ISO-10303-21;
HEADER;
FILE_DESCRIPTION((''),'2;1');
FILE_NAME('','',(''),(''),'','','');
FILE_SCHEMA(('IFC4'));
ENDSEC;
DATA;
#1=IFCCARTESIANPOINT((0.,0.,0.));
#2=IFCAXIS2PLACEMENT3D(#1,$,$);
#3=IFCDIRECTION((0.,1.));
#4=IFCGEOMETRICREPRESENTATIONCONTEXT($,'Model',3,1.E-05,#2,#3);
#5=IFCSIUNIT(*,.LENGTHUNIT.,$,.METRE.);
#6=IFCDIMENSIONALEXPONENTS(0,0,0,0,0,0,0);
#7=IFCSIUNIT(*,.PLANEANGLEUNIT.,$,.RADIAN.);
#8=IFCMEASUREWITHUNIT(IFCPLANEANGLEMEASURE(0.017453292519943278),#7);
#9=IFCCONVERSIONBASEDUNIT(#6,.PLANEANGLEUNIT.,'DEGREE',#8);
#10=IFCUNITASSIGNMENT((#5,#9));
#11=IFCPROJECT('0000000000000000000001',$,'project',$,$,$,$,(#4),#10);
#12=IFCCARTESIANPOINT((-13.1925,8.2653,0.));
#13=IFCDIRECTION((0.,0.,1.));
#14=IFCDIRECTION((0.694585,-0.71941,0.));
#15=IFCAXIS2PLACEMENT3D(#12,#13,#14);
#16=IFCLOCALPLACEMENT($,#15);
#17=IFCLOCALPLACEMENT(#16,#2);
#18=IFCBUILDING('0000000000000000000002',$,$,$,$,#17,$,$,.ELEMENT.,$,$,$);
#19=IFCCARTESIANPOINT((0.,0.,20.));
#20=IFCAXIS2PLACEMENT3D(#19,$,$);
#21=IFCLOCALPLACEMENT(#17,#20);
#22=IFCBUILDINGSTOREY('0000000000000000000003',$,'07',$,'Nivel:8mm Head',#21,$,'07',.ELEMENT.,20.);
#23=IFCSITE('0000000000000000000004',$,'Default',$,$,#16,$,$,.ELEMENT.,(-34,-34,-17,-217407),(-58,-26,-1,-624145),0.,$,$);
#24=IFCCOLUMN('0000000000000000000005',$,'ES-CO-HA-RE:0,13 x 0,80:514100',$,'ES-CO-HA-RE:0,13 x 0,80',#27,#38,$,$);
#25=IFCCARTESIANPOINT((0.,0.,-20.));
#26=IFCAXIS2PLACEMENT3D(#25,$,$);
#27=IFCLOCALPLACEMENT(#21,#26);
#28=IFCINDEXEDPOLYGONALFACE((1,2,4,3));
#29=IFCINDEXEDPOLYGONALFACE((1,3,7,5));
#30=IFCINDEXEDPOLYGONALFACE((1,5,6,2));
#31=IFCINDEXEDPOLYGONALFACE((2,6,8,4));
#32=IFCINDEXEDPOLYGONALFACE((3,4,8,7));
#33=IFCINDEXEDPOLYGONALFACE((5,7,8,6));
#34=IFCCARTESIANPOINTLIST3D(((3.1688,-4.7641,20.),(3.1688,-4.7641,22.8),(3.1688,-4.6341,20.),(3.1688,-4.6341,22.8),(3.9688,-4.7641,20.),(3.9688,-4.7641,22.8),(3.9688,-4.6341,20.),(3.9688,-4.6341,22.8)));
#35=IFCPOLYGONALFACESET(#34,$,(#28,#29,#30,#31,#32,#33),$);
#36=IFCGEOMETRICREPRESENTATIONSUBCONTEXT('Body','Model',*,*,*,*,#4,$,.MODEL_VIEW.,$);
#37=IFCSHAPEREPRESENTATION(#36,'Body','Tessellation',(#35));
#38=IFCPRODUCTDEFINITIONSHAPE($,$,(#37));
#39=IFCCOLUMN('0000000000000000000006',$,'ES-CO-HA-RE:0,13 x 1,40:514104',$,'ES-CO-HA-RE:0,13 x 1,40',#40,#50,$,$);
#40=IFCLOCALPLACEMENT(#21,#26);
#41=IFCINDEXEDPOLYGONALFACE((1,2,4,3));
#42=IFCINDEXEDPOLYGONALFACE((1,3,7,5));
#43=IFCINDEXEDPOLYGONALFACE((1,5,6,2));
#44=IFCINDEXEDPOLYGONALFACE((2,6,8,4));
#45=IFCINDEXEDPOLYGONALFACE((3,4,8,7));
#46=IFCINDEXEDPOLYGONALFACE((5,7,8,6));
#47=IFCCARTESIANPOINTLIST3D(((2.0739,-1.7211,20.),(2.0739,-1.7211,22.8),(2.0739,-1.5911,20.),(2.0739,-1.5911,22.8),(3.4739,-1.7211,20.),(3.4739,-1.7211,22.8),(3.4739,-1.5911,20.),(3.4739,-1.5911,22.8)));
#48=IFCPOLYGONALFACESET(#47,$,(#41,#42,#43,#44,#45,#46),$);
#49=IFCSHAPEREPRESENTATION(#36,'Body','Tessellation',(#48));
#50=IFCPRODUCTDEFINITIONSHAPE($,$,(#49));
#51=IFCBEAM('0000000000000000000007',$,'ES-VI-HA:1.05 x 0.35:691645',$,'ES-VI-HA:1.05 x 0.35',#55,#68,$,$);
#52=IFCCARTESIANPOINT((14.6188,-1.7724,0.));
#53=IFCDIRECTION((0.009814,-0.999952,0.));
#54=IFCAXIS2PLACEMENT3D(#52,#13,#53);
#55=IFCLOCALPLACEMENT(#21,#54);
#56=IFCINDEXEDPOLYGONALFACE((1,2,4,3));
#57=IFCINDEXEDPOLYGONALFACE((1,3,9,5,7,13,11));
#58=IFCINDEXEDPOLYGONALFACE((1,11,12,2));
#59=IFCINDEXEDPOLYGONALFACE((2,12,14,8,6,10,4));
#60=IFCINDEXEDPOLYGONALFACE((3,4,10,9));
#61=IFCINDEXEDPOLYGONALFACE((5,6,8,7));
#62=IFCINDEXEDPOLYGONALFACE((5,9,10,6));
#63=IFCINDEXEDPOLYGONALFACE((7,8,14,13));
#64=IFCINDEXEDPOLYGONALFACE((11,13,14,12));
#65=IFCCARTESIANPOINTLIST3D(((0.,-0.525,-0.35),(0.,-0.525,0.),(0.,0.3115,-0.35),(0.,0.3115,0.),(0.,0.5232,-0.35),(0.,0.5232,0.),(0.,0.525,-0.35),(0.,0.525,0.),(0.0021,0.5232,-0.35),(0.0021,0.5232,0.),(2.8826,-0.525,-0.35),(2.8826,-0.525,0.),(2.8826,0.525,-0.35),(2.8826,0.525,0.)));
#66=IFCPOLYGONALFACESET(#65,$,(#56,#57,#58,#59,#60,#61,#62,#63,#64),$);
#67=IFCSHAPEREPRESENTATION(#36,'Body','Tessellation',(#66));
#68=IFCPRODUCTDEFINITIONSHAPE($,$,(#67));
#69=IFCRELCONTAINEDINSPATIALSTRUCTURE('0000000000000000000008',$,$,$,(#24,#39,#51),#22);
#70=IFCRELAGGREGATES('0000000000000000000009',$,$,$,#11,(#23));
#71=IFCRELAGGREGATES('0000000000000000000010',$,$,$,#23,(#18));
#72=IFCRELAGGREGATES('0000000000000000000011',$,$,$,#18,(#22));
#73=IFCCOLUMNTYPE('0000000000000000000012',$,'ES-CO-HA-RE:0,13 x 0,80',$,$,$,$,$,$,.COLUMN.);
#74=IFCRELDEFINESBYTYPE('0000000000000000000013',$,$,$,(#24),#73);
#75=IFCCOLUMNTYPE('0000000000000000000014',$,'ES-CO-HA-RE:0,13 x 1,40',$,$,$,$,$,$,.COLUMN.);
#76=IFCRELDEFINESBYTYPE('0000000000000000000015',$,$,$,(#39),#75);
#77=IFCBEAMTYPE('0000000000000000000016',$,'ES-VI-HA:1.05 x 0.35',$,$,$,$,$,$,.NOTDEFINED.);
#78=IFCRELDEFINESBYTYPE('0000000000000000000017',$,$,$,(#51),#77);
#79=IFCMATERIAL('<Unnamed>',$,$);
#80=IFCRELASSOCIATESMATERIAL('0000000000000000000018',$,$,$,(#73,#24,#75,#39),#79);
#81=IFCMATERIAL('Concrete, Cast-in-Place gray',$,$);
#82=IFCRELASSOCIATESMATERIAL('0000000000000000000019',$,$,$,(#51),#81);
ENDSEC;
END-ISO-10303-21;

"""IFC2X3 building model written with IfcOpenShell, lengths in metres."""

from ifc_helpers import new_model, entity, si_unit, converted_unit, direction, frame, frame_2d, origin, place, context, subcontext, project, spatial, polyline, rectangle, extrude, clip, bounded_halfspace, source, transform, mapped, material, type_object, type_shapes, element, save


model = new_model("IFC2X3")

# Units and contexts
model_context = context("Model", 3, precision=1e-05, world=origin(), true_north=direction((0.0, 1.0)))
body_context = subcontext(model_context, "Body", "Model", "MODEL_VIEW")
ifc_project = project(units=[si_unit("LENGTHUNIT", "METRE"), converted_unit("PLANEANGLEUNIT", "DEGREE", entity("IfcPlaneAngleMeasure", 0.017453292519943278), si_unit("PLANEANGLEUNIT", "RADIAN"), dimensions=[0, 0, 0, 0, 0, 0, 0])], contexts=[model_context])

# Site, building, storey
site_placement = place(None, frame((-13.1925, 8.2653, 0.0), z_axis=(0.0, 0.0, 1.0), x_axis=(0.694585, -0.71941, 0.0)))
site = spatial("IfcSite", under=ifc_project, at=site_placement, Name="Default", CompositionType="ELEMENT", RefLatitude=(-34, -34, -17, -217407), RefLongitude=(-58, -26, -1, -624145), RefElevation=0.0)
building_placement = place(site_placement, origin())
building = spatial("IfcBuilding", under=site, at=building_placement, CompositionType="ELEMENT")
storey_placement = place(building_placement, frame((0.0, 0.0, 20.0)))
storey = spatial("IfcBuildingStorey", under=building, at=storey_placement, Name="07", ObjectType="Nivel:8mm Head", LongName="07", CompositionType="ELEMENT", Elevation=20.0)

# Columns
ifc_material_1 = material(Name="<Unnamed>")
column_type_1 = type_object("IfcColumnType", Name="ES-CO-HA-RE:0,13 x 0,80", PredefinedType="COLUMN", material=ifc_material_1)
shared_shape_1 = source(origin(), body_context, "Body", "SweptSolid", [
    extrude(rectangle(XDim=0.8, YDim=0.13, at=frame_2d((0.0, 0.0), x_axis=(1.0, 0.0))), frame((3.5688, -4.6991, 20.0), z_axis=(0.0, 0.0, 1.0), x_axis=(-1.0, 0.0, 0.0)), (0.0, 0.0, 1.0), 2.8),
])
type_shapes(column_type_1, [shared_shape_1])
column_1_placement = place(storey_placement, frame((0.0, 0.0, -20.0)))
element("IfcColumn", 1, at=column_1_placement, inside=storey, type_object=column_type_1, material=ifc_material_1, Name="ES-CO-HA-RE:0,13 x 0,80:514100", ObjectType="ES-CO-HA-RE:0,13 x 0,80", context=body_context, shape_type="MappedRepresentation", body=[
    mapped(shared_shape_1, transform((0.0, 0.0, 0.0), scale=1.0)),
])
column_type_2 = type_object("IfcColumnType", Name="ES-CO-HA-RE:0,13 x 1,40", PredefinedType="COLUMN", material=ifc_material_1)
shared_shape_2 = source(origin(), body_context, "Body", "SweptSolid", [
    extrude(rectangle(XDim=1.4, YDim=0.13, at=frame_2d((0.0, 0.0), x_axis=(1.0, 0.0))), frame((2.7739, -1.6561, 20.0), z_axis=(0.0, 0.0, 1.0), x_axis=(-1.0, 0.0, 0.0)), (0.0, 0.0, 1.0), 2.8),
])
type_shapes(column_type_2, [shared_shape_2])
column_2_placement = place(storey_placement, frame((0.0, 0.0, -20.0)))
element("IfcColumn", 2, at=column_2_placement, inside=storey, type_object=column_type_2, material=ifc_material_1, Name="ES-CO-HA-RE:0,13 x 1,40:514104", ObjectType="ES-CO-HA-RE:0,13 x 1,40", context=body_context, shape_type="MappedRepresentation", body=[
    mapped(shared_shape_2, transform((0.0, 0.0, 0.0), scale=1.0)),
])

# Beam
ifc_material_2 = material(Name="Concrete, Cast-in-Place gray")
beam_type_1 = type_object("IfcBeamType", Name="ES-VI-HA:1.05 x 0.35", PredefinedType="NOTDEFINED")
beam_1_placement = place(storey_placement, frame((14.6188, -1.7724, 0.0), z_axis=(0.0, 0.0, 1.0), x_axis=(0.009814, -0.999952, 0.0)))
element("IfcBeam", 3, at=beam_1_placement, inside=storey, type_object=beam_type_1, material=ifc_material_2, Name="ES-VI-HA:1.05 x 0.35:691645", ObjectType="ES-VI-HA:1.05 x 0.35", context=body_context, shape_type="SweptSolid", body=[
    clip(clip(extrude(rectangle(XDim=0.35, YDim=1.05, at=frame_2d((0.0, 0.0), x_axis=(1.0, 0.0))), frame((0.0, 0.0, -0.175), z_axis=(1.0, 0.0, 0.0), x_axis=(0.0, 0.0, -1.0)), (0.0, 0.0, 1.0), 2.8826), bounded_halfspace(frame((0.0021, 0.5232, 0.0), z_axis=(-0.009814, -0.999952, 0.0), x_axis=(0.0, 0.0, -1.0)), False, frame((0.0, 0.0, -0.175), z_axis=(1.0, 0.0, 0.0), x_axis=(0.0, 0.0, -1.0)), polyline([(0.175, 0.5232), (-0.175, 0.5232), (-0.175, 0.5232), (0.175, 0.5232), (0.175, 0.5232)]))), bounded_halfspace(frame((-0.0082, -0.5268, 0.0), z_axis=(-0.999952, 0.009814, 0.0), x_axis=(0.0, 0.0, -1.0)), False, frame((0.0, 0.0, -0.175), z_axis=(1.0, 0.0, 0.0), x_axis=(0.0, 0.0, -1.0)), polyline([(-0.175, 0.5232), (0.175, 0.5232), (0.175, 0.3115), (-0.175, 0.3115), (-0.175, 0.5232)]))),
])

save(model, "model.ifc")
